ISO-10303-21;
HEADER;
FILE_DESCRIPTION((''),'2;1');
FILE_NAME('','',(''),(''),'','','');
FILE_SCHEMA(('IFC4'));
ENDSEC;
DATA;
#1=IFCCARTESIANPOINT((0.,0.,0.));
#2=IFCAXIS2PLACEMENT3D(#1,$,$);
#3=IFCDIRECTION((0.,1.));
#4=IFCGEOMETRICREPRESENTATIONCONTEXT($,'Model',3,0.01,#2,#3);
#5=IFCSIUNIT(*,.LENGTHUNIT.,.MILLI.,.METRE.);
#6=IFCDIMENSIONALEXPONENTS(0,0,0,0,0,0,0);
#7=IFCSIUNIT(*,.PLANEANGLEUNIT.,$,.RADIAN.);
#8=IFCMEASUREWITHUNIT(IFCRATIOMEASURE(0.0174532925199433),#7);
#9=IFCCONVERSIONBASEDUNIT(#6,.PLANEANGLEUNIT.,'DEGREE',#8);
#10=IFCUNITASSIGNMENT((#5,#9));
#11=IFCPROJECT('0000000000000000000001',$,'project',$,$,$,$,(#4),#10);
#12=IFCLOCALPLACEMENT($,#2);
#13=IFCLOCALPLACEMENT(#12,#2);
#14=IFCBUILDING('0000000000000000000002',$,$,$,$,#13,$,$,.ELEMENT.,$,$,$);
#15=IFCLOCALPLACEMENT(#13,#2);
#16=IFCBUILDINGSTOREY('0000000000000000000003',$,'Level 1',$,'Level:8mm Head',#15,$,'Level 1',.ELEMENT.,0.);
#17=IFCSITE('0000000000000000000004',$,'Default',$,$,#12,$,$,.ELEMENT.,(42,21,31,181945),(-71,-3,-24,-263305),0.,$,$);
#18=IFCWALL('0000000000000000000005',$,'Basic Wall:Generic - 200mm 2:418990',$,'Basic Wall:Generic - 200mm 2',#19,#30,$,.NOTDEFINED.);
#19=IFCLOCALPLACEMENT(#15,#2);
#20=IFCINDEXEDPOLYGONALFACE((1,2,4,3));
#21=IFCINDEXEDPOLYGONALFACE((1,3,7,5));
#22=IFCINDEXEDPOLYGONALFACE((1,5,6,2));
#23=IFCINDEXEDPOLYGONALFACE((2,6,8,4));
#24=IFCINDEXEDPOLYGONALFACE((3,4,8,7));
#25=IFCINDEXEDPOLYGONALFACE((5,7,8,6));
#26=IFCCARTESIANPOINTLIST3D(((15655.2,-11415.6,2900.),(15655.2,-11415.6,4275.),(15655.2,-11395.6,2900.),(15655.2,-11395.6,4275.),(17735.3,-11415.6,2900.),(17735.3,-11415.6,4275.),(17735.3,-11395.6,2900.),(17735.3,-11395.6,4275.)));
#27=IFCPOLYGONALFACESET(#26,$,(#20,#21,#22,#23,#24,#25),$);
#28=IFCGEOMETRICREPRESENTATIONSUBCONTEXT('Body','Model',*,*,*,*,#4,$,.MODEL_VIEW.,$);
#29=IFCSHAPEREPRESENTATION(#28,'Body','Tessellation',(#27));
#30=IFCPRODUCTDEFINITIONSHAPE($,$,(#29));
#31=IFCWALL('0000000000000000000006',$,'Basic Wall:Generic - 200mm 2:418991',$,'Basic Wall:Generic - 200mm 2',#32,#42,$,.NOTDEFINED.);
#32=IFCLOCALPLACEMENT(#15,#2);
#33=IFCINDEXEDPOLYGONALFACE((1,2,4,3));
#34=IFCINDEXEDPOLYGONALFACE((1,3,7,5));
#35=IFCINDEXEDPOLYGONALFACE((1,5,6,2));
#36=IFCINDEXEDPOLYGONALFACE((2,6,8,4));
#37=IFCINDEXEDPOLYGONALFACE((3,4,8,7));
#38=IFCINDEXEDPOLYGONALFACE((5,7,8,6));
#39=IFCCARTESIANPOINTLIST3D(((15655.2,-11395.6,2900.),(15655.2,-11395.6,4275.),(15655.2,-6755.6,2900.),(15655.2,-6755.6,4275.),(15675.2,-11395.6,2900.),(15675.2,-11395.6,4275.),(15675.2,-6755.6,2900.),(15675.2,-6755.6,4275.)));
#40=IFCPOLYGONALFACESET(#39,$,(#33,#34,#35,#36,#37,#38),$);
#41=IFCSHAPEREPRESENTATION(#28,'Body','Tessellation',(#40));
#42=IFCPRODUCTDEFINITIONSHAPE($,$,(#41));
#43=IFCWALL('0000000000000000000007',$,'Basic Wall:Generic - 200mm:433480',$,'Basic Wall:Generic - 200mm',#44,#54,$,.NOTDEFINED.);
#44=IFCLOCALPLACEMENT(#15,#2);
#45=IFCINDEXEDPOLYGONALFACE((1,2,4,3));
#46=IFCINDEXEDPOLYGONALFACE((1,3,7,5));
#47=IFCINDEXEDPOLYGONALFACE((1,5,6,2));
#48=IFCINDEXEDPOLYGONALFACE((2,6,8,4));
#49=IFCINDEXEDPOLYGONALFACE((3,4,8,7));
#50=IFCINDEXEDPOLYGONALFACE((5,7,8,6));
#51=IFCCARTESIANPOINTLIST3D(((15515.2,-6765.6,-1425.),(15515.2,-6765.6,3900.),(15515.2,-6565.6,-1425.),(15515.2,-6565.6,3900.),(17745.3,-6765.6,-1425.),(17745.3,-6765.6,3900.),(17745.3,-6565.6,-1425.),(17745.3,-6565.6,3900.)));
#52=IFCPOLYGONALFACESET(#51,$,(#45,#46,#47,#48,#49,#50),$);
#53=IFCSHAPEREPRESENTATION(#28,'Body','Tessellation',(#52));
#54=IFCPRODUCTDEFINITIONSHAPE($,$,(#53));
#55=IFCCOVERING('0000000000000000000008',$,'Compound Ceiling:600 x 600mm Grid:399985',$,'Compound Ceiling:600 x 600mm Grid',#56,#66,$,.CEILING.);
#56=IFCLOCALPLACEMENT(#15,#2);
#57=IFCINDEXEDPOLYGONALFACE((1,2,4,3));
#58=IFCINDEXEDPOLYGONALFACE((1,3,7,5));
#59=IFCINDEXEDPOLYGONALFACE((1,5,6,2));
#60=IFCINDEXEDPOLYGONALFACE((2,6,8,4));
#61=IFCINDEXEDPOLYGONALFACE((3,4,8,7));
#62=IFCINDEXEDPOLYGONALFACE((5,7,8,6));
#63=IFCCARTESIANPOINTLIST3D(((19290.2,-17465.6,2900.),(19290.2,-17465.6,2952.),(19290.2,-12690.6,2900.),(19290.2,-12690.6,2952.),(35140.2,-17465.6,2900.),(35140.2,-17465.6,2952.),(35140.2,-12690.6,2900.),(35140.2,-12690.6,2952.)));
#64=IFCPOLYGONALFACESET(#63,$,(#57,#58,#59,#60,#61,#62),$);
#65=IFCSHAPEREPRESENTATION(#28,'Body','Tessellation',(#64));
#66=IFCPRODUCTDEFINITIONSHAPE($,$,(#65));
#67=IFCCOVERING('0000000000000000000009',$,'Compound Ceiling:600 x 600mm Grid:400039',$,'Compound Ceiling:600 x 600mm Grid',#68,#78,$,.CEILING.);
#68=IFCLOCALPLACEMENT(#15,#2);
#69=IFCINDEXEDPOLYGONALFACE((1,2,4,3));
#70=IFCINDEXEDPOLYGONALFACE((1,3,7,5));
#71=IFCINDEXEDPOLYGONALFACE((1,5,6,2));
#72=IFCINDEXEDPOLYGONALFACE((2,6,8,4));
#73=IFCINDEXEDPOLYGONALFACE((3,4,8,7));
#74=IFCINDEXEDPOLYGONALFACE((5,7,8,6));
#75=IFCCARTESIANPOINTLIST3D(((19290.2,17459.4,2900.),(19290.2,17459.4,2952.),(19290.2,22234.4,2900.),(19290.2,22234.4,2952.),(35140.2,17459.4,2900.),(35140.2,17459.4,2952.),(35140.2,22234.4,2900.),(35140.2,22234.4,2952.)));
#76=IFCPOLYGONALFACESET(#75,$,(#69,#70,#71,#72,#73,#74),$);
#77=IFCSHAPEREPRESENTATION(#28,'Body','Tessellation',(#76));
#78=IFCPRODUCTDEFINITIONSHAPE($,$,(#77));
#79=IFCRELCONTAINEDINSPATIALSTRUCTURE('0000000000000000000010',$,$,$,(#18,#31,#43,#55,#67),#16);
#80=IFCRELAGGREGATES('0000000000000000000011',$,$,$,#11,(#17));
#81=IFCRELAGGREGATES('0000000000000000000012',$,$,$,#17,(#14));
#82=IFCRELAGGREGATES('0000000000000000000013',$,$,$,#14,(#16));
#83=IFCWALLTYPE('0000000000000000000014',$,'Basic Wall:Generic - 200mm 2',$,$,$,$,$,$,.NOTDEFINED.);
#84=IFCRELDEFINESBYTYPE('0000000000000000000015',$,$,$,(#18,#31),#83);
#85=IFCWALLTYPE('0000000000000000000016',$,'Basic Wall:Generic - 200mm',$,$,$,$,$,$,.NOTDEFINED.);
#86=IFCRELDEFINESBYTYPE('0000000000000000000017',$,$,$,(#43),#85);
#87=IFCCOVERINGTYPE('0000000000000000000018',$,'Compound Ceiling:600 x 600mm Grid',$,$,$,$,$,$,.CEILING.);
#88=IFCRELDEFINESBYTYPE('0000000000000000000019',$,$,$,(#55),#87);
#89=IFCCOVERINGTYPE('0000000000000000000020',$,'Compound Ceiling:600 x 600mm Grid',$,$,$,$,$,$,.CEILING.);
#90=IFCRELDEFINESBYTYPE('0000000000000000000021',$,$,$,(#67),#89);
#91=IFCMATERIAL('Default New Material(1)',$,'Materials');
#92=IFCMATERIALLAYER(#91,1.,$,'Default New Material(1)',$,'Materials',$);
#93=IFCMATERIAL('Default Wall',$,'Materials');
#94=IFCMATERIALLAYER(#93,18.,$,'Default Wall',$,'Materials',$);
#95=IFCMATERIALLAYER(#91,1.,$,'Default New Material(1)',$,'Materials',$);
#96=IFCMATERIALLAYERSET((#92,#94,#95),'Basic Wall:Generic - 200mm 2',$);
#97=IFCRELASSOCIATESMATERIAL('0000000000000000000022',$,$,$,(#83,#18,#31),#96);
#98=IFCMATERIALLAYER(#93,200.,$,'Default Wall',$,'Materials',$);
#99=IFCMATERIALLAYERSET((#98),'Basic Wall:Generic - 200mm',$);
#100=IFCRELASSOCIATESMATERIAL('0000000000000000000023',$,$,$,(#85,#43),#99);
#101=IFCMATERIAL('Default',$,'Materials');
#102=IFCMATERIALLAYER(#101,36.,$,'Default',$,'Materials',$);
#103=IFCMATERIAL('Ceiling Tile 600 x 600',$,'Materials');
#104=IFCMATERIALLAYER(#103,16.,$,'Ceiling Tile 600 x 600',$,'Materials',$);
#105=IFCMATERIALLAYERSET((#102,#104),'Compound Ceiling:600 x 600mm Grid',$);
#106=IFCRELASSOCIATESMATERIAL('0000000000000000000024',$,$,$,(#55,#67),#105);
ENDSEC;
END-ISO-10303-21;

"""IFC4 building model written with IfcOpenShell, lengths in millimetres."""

from ifc_helpers import new_model, entity, si_unit, converted_unit, direction, frame, origin, place, context, subcontext, project, spatial, indexed_curve, outline, extrude, material, layer, layer_set, type_object, element, save


model = new_model("IFC4")

# Units and contexts
model_context = context("Model", 3, precision=0.01, world=origin(), true_north=direction((0.0, 1.0)))
body_context = subcontext(model_context, "Body", "Model", "MODEL_VIEW")
ifc_project = project(units=[si_unit("LENGTHUNIT", "METRE", prefix="MILLI"), converted_unit("PLANEANGLEUNIT", "DEGREE", entity("IfcRatioMeasure", 0.0174532925199433), si_unit("PLANEANGLEUNIT", "RADIAN"), dimensions=[0, 0, 0, 0, 0, 0, 0])], contexts=[model_context])

# Site, building, storey
site_placement = place(None, origin())
site = spatial("IfcSite", under=ifc_project, at=site_placement, Name="Default", CompositionType="ELEMENT", RefLatitude=(42, 21, 31, 181945), RefLongitude=(-71, -3, -24, -263305), RefElevation=0.0)
building_placement = place(site_placement, origin())
building = spatial("IfcBuilding", under=site, at=building_placement, CompositionType="ELEMENT")
storey_placement = place(building_placement, origin())
storey = spatial("IfcBuildingStorey", under=building, at=storey_placement, Name="Level 1", ObjectType="Level:8mm Head", LongName="Level 1", CompositionType="ELEMENT", Elevation=0.0)

# Walls
ifc_material_1 = material(Name="Default Wall", Category="Materials")
ifc_material_2 = material(Name="Default New Material(1)", Category="Materials")
ifc_layer_1 = layer(ifc_material_2, 1.0, Name="Default New Material(1)", Category="Materials")
ifc_layer_2 = layer(ifc_material_1, 18.0, Name="Default Wall", Category="Materials")
ifc_layer_3 = layer(ifc_material_2, 1.0, Name="Default New Material(1)", Category="Materials")
ifc_layer_set_1 = layer_set([ifc_layer_1, ifc_layer_2, ifc_layer_3], Name="Basic Wall:Generic - 200mm 2")
wall_type_1 = type_object("IfcWallType", Name="Basic Wall:Generic - 200mm 2", PredefinedType="NOTDEFINED", material=ifc_layer_set_1)
wall_1_placement = place(storey_placement, frame((15655.2, -11405.6, 2900.0)))
element("IfcWall", 1, at=wall_1_placement, inside=storey, type_object=wall_type_1, material=ifc_layer_set_1, Name="Basic Wall:Generic - 200mm 2:418990", ObjectType="Basic Wall:Generic - 200mm 2", PredefinedType="NOTDEFINED", context=body_context, shape_type="SweptSolid", body=[
    extrude(outline(indexed_curve([(2080.1, 10.0), (0.0, 10.0), (0.0, -10.0), (2080.1, -10.0), (2080.1, 10.0)], self_intersect=False)), origin(), (0.0, 0.0, 1.0), 1375.0),
])
wall_2_placement = place(storey_placement, frame((15665.2, -6755.6, 2900.0), z_axis=(0.0, 0.0, 1.0), x_axis=(0.0, -1.0, 0.0)))
element("IfcWall", 2, at=wall_2_placement, inside=storey, type_object=wall_type_1, material=ifc_layer_set_1, Name="Basic Wall:Generic - 200mm 2:418991", ObjectType="Basic Wall:Generic - 200mm 2", PredefinedType="NOTDEFINED", context=body_context, shape_type="SweptSolid", body=[
    extrude(outline(indexed_curve([(4640.0, 10.0), (0.0, 10.0), (0.0, -10.0), (4640.0, -10.0), (4640.0, 10.0)], self_intersect=False)), origin(), (0.0, 0.0, 1.0), 1375.0),
])
ifc_layer_4 = layer(ifc_material_1, 200.0, Name="Default Wall", Category="Materials")
ifc_layer_set_2 = layer_set([ifc_layer_4], Name="Basic Wall:Generic - 200mm")
wall_type_2 = type_object("IfcWallType", Name="Basic Wall:Generic - 200mm", PredefinedType="NOTDEFINED", material=ifc_layer_set_2)
wall_3_placement = place(building_placement, frame((15515.2, -6665.6, -1425.0)))
element("IfcWall", 3, at=wall_3_placement, inside=storey, type_object=wall_type_2, material=ifc_layer_set_2, Name="Basic Wall:Generic - 200mm:433480", ObjectType="Basic Wall:Generic - 200mm", PredefinedType="NOTDEFINED", context=body_context, shape_type="SweptSolid", body=[
    extrude(outline(indexed_curve([(2230.1, 100.0), (0.0, 100.0), (0.0, -100.0), (2230.1, -100.0), (2230.1, 100.0)], self_intersect=False)), origin(), (0.0, 0.0, 1.0), 5325.0),
])

# Coverings
ifc_material_3 = material(Name="Default", Category="Materials")
ifc_layer_5 = layer(ifc_material_3, 36.0, Name="Default", Category="Materials")
ifc_material_4 = material(Name="Ceiling Tile 600 x 600", Category="Materials")
ifc_layer_6 = layer(ifc_material_4, 16.0, Name="Ceiling Tile 600 x 600", Category="Materials")
ifc_layer_set_3 = layer_set([ifc_layer_5, ifc_layer_6], Name="Compound Ceiling:600 x 600mm Grid")
covering_type_1 = type_object("IfcCoveringType", Name="Compound Ceiling:600 x 600mm Grid", PredefinedType="CEILING")
covering_1_placement = place(storey_placement, origin())
element("IfcCovering", 4, at=covering_1_placement, inside=storey, type_object=covering_type_1, material=ifc_layer_set_3, Name="Compound Ceiling:600 x 600mm Grid:399985", ObjectType="Compound Ceiling:600 x 600mm Grid", PredefinedType="CEILING", context=body_context, shape_type="SweptSolid", body=[
    extrude(outline(indexed_curve([(-7925.0, -2387.5), (7925.0, -2387.5), (7925.0, 2387.5), (-7925.0, 2387.5), (-7925.0, -2387.5)], self_intersect=False)), frame((27215.2, -15078.1, 2900.0), z_axis=(0.0, 0.0, 1.0), x_axis=(-1.0, 0.0, 0.0)), (0.0, 0.0, 1.0), 52.0),
])
covering_type_2 = type_object("IfcCoveringType", Name="Compound Ceiling:600 x 600mm Grid", PredefinedType="CEILING")
covering_2_placement = place(storey_placement, origin())
element("IfcCovering", 5, at=covering_2_placement, inside=storey, type_object=covering_type_2, material=ifc_layer_set_3, Name="Compound Ceiling:600 x 600mm Grid:400039", ObjectType="Compound Ceiling:600 x 600mm Grid", PredefinedType="CEILING", context=body_context, shape_type="SweptSolid", body=[
    extrude(outline(indexed_curve([(-2387.5, -7925.0), (2387.5, -7925.0), (2387.5, 7925.0), (-2387.5, 7925.0), (-2387.5, -7925.0)], self_intersect=False)), frame((27215.2, 19846.9, 2900.0), z_axis=(0.0, 0.0, 1.0), x_axis=(0.0, 1.0, 0.0)), (0.0, 0.0, 1.0), 52.0),
])

save(model, "model.ifc")
